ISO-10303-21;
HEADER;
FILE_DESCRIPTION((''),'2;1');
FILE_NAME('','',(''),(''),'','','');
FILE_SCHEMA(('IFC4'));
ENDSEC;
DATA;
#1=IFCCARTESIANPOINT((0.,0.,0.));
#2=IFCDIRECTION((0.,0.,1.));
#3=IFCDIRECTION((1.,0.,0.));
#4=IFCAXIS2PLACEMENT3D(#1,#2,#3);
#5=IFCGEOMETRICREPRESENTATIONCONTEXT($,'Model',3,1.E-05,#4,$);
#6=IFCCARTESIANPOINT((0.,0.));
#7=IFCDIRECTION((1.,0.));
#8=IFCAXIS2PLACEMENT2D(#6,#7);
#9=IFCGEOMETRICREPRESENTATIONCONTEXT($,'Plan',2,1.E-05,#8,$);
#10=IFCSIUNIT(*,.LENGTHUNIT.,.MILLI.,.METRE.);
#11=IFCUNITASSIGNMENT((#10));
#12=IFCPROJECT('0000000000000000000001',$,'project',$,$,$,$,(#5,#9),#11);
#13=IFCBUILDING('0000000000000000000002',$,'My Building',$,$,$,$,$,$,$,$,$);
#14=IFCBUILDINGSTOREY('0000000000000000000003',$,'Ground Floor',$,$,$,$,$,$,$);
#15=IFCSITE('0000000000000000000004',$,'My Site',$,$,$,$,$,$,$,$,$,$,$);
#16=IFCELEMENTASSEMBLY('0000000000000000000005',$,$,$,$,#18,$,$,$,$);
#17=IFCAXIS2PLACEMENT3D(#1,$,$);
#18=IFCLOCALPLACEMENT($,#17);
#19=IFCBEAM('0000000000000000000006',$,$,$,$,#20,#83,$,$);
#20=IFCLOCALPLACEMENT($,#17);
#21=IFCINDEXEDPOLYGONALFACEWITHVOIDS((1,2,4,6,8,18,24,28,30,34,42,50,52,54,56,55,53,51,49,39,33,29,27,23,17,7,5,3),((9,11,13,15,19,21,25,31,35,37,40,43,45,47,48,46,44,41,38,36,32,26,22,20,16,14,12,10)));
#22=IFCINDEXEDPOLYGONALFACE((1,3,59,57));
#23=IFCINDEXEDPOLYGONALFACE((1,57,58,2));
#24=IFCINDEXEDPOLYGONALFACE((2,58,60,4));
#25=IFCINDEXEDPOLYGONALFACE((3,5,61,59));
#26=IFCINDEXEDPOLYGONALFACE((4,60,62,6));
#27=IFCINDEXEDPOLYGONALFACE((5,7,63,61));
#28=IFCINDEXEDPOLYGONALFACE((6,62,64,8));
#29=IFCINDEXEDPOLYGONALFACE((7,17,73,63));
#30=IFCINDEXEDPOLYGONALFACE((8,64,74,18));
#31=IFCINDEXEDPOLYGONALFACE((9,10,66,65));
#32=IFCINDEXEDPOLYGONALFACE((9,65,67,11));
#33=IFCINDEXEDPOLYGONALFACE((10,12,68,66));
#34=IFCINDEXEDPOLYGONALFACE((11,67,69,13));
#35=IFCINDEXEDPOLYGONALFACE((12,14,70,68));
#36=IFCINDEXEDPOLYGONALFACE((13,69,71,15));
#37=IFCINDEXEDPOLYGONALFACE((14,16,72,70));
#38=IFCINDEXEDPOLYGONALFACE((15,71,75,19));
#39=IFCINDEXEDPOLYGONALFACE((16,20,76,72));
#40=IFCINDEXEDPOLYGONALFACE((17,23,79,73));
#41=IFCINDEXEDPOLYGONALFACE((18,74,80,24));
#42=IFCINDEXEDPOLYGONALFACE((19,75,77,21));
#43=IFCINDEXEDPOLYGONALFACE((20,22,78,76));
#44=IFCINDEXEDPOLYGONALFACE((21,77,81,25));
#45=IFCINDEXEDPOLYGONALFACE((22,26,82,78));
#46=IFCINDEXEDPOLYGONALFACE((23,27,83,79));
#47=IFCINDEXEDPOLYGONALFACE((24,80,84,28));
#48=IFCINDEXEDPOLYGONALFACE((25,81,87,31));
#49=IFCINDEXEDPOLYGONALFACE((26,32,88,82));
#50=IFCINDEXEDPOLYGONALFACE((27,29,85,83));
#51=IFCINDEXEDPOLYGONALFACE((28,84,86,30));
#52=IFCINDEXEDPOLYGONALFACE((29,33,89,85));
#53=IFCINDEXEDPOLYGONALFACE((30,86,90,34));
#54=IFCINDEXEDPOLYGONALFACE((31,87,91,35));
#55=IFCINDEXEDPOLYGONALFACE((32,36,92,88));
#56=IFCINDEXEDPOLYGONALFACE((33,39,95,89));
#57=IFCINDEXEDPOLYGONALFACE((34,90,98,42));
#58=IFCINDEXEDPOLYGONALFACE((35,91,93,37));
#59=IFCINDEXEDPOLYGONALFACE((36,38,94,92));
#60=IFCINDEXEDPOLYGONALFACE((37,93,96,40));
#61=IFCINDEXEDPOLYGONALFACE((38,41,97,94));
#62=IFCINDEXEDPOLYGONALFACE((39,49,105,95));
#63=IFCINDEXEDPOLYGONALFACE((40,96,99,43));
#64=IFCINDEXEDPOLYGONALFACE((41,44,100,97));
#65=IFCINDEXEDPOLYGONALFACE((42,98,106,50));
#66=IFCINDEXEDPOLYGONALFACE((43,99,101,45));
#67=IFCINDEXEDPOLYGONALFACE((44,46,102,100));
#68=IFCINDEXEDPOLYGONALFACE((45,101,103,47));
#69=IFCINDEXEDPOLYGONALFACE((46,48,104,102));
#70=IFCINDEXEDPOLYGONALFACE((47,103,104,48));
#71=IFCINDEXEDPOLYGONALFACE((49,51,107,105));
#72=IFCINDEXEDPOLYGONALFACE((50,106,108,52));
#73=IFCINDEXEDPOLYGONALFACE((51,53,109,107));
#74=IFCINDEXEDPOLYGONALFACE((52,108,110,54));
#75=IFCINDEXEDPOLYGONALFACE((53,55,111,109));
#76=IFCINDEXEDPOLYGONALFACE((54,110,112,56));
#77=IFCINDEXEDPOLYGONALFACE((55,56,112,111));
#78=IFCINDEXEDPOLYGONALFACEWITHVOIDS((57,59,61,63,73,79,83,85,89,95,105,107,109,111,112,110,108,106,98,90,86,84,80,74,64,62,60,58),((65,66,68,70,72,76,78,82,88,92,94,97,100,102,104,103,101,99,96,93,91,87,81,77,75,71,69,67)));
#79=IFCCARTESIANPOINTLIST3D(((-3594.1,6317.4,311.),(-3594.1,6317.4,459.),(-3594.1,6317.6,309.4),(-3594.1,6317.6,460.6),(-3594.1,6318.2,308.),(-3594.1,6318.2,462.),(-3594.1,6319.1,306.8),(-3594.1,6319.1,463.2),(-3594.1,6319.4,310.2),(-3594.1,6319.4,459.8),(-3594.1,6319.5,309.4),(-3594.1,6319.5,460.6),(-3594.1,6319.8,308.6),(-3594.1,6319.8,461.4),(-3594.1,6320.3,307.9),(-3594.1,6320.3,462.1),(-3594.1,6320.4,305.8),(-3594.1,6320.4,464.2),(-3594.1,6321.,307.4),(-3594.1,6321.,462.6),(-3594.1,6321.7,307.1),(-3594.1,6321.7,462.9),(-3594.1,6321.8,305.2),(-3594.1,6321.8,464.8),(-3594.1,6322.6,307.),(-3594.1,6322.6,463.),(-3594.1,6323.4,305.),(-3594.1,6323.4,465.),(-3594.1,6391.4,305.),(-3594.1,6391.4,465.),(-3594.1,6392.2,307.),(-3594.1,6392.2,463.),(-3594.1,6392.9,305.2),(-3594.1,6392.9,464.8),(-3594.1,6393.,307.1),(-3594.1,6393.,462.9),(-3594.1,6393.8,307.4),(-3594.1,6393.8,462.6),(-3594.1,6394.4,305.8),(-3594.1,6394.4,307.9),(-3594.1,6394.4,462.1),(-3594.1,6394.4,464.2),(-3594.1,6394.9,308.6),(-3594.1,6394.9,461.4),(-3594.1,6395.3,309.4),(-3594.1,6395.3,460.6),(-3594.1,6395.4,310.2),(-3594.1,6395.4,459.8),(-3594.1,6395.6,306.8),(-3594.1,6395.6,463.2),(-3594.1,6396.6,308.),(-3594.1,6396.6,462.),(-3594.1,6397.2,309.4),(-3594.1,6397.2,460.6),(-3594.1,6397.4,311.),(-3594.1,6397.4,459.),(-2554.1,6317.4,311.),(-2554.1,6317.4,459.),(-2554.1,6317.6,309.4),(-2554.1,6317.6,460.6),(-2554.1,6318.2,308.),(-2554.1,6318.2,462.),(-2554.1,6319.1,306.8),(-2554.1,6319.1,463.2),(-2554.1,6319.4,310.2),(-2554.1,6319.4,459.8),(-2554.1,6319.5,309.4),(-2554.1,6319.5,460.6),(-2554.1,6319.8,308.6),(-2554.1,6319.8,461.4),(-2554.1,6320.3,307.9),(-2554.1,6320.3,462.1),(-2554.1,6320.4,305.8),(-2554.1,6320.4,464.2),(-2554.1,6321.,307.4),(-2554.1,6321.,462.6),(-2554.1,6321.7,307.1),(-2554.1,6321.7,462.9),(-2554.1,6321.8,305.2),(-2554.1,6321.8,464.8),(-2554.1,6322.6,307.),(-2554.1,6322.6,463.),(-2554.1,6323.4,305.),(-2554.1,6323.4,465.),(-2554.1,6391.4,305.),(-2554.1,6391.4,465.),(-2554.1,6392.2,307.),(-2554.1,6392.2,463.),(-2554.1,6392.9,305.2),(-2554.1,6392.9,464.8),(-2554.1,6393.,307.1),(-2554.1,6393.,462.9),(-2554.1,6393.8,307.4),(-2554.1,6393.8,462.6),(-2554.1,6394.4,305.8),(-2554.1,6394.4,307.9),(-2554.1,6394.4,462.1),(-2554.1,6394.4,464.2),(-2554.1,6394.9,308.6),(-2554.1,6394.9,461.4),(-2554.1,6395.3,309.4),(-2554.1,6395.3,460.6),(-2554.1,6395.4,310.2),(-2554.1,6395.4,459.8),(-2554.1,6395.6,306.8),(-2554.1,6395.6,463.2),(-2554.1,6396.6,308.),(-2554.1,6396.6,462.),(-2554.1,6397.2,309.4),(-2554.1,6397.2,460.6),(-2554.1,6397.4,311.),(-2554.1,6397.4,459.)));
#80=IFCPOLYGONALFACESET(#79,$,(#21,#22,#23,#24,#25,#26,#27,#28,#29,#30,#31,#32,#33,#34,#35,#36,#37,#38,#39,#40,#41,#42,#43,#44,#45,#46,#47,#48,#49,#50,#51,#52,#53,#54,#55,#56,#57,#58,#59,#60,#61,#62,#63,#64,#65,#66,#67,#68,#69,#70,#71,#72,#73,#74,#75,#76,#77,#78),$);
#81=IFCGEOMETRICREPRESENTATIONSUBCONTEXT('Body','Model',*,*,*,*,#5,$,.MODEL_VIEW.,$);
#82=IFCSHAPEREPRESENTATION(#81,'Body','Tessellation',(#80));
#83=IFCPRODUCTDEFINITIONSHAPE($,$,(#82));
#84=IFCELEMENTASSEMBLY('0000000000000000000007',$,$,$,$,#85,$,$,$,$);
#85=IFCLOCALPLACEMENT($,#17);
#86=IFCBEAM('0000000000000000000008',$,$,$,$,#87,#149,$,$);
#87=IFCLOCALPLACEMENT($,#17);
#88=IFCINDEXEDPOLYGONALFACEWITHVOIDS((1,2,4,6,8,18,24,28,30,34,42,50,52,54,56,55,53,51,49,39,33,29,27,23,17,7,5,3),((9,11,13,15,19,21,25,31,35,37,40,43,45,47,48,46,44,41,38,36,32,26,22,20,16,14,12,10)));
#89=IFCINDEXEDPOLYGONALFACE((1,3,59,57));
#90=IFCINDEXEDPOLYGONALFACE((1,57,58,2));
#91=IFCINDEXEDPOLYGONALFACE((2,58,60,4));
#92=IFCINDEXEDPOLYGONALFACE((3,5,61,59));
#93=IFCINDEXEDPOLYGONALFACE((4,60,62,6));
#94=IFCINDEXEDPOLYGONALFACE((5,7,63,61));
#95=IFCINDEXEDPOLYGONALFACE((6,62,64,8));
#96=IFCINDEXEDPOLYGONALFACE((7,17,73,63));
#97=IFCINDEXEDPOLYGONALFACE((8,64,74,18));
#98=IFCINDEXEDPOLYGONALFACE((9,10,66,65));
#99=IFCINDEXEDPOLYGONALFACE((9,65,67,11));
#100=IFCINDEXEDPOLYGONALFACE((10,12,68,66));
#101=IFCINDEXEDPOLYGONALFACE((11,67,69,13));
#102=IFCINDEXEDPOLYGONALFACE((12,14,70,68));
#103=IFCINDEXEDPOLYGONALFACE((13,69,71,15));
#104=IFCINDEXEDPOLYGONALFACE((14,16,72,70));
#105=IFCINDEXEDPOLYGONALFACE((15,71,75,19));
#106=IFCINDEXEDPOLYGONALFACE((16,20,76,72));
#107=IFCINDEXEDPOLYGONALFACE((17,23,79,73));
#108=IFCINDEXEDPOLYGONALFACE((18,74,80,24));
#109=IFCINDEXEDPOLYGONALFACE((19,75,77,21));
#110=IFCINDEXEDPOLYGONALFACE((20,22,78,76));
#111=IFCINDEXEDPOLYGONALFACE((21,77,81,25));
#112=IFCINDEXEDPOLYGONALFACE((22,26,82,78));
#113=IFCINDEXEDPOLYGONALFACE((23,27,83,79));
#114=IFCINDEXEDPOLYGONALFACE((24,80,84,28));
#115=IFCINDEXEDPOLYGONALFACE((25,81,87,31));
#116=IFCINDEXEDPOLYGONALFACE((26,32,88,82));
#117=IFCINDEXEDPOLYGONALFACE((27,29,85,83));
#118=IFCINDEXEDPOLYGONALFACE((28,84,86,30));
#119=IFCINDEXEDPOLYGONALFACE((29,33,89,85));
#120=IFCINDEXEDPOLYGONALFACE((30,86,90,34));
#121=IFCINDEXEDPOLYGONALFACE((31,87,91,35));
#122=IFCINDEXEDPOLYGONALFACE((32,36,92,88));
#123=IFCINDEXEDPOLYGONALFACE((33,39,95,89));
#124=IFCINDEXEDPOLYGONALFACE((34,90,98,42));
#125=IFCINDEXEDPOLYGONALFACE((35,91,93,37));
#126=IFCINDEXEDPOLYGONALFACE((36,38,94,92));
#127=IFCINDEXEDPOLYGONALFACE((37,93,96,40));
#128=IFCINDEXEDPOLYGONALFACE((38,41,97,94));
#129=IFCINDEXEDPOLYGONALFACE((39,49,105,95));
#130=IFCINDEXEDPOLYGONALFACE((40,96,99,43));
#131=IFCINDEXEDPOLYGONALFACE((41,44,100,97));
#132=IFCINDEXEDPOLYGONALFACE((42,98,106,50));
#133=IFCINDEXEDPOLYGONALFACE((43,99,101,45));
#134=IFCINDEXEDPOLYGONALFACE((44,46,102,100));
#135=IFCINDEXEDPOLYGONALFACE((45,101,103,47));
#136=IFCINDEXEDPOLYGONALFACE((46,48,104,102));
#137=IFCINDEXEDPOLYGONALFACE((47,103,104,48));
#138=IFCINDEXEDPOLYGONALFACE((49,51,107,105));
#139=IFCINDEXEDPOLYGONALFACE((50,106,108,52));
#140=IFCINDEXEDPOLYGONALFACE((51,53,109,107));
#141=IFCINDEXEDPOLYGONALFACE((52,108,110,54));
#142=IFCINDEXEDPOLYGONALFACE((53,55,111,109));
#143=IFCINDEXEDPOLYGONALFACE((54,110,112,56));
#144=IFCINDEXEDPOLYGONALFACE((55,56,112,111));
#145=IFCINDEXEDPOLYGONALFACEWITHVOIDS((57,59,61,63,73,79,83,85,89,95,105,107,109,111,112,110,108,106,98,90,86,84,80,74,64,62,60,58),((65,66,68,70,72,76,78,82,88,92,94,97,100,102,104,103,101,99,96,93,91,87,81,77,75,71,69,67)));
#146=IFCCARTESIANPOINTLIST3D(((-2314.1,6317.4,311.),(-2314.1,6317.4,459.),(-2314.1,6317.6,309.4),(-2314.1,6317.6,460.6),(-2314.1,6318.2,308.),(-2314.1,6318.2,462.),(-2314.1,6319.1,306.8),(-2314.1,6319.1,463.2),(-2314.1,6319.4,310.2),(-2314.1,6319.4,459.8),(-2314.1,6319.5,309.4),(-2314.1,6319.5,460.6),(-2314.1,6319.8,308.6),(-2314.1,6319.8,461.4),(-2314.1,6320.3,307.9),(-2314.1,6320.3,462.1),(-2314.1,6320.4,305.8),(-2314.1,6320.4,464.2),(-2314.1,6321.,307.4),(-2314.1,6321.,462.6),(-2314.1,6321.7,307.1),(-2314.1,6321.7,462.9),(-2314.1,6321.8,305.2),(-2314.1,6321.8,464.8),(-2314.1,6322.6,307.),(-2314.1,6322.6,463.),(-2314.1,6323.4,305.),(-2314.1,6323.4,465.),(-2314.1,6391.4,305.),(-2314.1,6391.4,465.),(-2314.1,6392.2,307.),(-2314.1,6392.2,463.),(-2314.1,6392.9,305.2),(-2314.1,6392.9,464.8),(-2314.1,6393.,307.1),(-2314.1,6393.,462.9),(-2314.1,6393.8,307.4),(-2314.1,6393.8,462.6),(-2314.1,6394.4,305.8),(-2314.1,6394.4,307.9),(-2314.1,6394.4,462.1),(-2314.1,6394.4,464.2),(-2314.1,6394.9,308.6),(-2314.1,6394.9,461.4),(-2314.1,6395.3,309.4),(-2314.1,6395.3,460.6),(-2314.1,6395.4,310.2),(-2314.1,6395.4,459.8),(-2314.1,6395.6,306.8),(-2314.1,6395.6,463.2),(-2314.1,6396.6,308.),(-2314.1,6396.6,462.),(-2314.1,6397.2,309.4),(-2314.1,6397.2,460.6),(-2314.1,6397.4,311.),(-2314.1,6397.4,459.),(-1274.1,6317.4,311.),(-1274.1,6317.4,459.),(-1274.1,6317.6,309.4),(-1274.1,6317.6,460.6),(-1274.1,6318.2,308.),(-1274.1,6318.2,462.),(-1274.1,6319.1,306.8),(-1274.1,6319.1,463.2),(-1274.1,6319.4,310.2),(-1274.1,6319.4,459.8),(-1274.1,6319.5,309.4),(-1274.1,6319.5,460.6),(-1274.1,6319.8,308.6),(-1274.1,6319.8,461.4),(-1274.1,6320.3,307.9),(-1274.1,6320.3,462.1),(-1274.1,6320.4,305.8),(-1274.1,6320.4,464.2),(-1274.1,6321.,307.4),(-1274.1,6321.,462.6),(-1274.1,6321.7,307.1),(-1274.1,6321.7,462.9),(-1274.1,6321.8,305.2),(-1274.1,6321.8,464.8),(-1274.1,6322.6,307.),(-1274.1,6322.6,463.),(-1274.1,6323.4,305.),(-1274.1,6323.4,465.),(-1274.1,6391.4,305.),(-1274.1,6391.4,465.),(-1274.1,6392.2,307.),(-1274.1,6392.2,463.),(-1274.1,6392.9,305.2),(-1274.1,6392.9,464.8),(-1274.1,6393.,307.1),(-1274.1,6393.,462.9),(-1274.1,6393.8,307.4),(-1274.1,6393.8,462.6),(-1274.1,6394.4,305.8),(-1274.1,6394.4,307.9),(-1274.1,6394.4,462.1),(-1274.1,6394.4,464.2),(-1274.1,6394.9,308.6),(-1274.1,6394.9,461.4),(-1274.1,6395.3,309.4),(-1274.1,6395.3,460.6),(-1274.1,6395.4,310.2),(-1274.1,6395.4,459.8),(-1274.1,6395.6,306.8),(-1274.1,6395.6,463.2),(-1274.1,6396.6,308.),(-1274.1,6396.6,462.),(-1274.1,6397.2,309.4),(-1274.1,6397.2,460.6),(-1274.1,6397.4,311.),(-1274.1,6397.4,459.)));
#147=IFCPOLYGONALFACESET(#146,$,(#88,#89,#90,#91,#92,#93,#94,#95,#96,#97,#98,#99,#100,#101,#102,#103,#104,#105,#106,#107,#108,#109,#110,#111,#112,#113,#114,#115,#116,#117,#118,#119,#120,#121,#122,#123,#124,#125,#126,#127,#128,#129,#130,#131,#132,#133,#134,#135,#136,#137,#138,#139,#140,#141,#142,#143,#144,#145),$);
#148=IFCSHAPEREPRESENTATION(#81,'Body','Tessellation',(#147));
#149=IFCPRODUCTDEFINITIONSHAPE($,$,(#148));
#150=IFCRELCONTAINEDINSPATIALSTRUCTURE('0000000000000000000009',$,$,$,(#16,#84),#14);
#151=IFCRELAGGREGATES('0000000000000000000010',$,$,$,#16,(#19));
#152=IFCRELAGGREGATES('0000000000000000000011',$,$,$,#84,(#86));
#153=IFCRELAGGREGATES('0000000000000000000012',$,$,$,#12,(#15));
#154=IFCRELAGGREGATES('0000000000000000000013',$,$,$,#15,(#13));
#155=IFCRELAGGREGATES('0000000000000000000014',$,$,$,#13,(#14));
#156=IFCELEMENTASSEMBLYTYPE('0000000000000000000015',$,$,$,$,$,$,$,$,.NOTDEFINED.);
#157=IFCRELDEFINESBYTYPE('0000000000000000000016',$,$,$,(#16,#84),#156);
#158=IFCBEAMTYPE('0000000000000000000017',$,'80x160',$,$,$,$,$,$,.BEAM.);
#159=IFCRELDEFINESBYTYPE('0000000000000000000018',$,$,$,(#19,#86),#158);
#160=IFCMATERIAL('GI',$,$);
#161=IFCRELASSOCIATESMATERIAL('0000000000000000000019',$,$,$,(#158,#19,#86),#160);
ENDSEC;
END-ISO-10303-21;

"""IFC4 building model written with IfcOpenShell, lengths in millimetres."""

from ifc_helpers import new_model, si_unit, frame, origin_with_axes, origin_2d_with_axis, place, context, subcontext, project, spatial, hollow_rectangle, extrude, material, material_profile, profile_set, profile_usage, type_object, element, aggregate, save


model = new_model("IFC4")

# Units and contexts
model_context = context("Model", 3, precision=1e-05, world=origin_with_axes())
plan_context = context("Plan", 2, precision=1e-05, world=origin_2d_with_axis())
body_context = subcontext(model_context, "Body", "Model", "MODEL_VIEW")
ifc_project = project(units=[si_unit("LENGTHUNIT", "METRE", prefix="MILLI")], contexts=[model_context, plan_context])

# Site, building, storey
site = spatial("IfcSite", under=ifc_project, Name="My Site")
building = spatial("IfcBuilding", under=site, Name="My Building")
storey = spatial("IfcBuildingStorey", under=building, Name="Ground Floor")

# Shared definitions
ifc_material = material(Name="GI")

# Element assemblies, beams
element_assembly_type_1 = type_object("IfcElementAssemblyType", PredefinedType="NOTDEFINED")
ifc_material_profile_1 = material_profile(ifc_material, hollow_rectangle(XDim=80.0, YDim=160.0, WallThickness=2.0, InnerFilletRadius=3.2, OuterFilletRadius=6.0))
ifc_profile_set_1 = profile_set([ifc_material_profile_1], Name="80x160 GI Rectangular Hollow")
beam_type = type_object("IfcBeamType", Name="80x160", PredefinedType="BEAM", material=ifc_profile_set_1)
assembly_1_placement = place(None, frame((-3674.1, 6357.4, 385.0), z_axis=(1.0, 0.0, 0.0), x_axis=(0.0, 1.0, 0.0)))
assembly_1 = element("IfcElementAssembly", 1, at=assembly_1_placement, inside=storey, type_object=element_assembly_type_1)
ifc_profile_usage_1 = profile_usage(ifc_profile_set_1)
beam_1_placement = place(assembly_1_placement, frame((0.0, 0.0, 80.0), z_axis=(0.0, 0.0, 1.0), x_axis=(1.0, 0.0, 0.0)))
beam_1 = element("IfcBeam", 2, at=beam_1_placement, type_object=beam_type, material=ifc_profile_usage_1, context=body_context, shape_type="SweptSolid", body=[
    extrude(hollow_rectangle(XDim=80.0, YDim=160.0, WallThickness=2.0, InnerFilletRadius=3.2, OuterFilletRadius=6.0), origin_with_axes(), (0.0, 0.0, 1.0), 1040.0),
])
aggregate(assembly_1, [beam_1])
assembly_2_placement = place(None, frame((-2394.1, 6357.4, 385.0), z_axis=(1.0, 0.0, 0.0), x_axis=(0.0, 1.0, 0.0)))
assembly_2 = element("IfcElementAssembly", 3, at=assembly_2_placement, inside=storey, type_object=element_assembly_type_1)
ifc_profile_usage_2 = profile_usage(ifc_profile_set_1)
beam_2_placement = place(assembly_2_placement, frame((0.0, 0.0, 80.0), z_axis=(0.0, 0.0, 1.0), x_axis=(1.0, 0.0, 0.0)))
beam_2 = element("IfcBeam", 4, at=beam_2_placement, type_object=beam_type, material=ifc_profile_usage_2, context=body_context, shape_type="SweptSolid", body=[
    extrude(hollow_rectangle(XDim=80.0, YDim=160.0, WallThickness=2.0, InnerFilletRadius=3.2, OuterFilletRadius=6.0), origin_with_axes(), (0.0, 0.0, 1.0), 1040.0),
])
aggregate(assembly_2, [beam_2])

save(model, "model.ifc")
